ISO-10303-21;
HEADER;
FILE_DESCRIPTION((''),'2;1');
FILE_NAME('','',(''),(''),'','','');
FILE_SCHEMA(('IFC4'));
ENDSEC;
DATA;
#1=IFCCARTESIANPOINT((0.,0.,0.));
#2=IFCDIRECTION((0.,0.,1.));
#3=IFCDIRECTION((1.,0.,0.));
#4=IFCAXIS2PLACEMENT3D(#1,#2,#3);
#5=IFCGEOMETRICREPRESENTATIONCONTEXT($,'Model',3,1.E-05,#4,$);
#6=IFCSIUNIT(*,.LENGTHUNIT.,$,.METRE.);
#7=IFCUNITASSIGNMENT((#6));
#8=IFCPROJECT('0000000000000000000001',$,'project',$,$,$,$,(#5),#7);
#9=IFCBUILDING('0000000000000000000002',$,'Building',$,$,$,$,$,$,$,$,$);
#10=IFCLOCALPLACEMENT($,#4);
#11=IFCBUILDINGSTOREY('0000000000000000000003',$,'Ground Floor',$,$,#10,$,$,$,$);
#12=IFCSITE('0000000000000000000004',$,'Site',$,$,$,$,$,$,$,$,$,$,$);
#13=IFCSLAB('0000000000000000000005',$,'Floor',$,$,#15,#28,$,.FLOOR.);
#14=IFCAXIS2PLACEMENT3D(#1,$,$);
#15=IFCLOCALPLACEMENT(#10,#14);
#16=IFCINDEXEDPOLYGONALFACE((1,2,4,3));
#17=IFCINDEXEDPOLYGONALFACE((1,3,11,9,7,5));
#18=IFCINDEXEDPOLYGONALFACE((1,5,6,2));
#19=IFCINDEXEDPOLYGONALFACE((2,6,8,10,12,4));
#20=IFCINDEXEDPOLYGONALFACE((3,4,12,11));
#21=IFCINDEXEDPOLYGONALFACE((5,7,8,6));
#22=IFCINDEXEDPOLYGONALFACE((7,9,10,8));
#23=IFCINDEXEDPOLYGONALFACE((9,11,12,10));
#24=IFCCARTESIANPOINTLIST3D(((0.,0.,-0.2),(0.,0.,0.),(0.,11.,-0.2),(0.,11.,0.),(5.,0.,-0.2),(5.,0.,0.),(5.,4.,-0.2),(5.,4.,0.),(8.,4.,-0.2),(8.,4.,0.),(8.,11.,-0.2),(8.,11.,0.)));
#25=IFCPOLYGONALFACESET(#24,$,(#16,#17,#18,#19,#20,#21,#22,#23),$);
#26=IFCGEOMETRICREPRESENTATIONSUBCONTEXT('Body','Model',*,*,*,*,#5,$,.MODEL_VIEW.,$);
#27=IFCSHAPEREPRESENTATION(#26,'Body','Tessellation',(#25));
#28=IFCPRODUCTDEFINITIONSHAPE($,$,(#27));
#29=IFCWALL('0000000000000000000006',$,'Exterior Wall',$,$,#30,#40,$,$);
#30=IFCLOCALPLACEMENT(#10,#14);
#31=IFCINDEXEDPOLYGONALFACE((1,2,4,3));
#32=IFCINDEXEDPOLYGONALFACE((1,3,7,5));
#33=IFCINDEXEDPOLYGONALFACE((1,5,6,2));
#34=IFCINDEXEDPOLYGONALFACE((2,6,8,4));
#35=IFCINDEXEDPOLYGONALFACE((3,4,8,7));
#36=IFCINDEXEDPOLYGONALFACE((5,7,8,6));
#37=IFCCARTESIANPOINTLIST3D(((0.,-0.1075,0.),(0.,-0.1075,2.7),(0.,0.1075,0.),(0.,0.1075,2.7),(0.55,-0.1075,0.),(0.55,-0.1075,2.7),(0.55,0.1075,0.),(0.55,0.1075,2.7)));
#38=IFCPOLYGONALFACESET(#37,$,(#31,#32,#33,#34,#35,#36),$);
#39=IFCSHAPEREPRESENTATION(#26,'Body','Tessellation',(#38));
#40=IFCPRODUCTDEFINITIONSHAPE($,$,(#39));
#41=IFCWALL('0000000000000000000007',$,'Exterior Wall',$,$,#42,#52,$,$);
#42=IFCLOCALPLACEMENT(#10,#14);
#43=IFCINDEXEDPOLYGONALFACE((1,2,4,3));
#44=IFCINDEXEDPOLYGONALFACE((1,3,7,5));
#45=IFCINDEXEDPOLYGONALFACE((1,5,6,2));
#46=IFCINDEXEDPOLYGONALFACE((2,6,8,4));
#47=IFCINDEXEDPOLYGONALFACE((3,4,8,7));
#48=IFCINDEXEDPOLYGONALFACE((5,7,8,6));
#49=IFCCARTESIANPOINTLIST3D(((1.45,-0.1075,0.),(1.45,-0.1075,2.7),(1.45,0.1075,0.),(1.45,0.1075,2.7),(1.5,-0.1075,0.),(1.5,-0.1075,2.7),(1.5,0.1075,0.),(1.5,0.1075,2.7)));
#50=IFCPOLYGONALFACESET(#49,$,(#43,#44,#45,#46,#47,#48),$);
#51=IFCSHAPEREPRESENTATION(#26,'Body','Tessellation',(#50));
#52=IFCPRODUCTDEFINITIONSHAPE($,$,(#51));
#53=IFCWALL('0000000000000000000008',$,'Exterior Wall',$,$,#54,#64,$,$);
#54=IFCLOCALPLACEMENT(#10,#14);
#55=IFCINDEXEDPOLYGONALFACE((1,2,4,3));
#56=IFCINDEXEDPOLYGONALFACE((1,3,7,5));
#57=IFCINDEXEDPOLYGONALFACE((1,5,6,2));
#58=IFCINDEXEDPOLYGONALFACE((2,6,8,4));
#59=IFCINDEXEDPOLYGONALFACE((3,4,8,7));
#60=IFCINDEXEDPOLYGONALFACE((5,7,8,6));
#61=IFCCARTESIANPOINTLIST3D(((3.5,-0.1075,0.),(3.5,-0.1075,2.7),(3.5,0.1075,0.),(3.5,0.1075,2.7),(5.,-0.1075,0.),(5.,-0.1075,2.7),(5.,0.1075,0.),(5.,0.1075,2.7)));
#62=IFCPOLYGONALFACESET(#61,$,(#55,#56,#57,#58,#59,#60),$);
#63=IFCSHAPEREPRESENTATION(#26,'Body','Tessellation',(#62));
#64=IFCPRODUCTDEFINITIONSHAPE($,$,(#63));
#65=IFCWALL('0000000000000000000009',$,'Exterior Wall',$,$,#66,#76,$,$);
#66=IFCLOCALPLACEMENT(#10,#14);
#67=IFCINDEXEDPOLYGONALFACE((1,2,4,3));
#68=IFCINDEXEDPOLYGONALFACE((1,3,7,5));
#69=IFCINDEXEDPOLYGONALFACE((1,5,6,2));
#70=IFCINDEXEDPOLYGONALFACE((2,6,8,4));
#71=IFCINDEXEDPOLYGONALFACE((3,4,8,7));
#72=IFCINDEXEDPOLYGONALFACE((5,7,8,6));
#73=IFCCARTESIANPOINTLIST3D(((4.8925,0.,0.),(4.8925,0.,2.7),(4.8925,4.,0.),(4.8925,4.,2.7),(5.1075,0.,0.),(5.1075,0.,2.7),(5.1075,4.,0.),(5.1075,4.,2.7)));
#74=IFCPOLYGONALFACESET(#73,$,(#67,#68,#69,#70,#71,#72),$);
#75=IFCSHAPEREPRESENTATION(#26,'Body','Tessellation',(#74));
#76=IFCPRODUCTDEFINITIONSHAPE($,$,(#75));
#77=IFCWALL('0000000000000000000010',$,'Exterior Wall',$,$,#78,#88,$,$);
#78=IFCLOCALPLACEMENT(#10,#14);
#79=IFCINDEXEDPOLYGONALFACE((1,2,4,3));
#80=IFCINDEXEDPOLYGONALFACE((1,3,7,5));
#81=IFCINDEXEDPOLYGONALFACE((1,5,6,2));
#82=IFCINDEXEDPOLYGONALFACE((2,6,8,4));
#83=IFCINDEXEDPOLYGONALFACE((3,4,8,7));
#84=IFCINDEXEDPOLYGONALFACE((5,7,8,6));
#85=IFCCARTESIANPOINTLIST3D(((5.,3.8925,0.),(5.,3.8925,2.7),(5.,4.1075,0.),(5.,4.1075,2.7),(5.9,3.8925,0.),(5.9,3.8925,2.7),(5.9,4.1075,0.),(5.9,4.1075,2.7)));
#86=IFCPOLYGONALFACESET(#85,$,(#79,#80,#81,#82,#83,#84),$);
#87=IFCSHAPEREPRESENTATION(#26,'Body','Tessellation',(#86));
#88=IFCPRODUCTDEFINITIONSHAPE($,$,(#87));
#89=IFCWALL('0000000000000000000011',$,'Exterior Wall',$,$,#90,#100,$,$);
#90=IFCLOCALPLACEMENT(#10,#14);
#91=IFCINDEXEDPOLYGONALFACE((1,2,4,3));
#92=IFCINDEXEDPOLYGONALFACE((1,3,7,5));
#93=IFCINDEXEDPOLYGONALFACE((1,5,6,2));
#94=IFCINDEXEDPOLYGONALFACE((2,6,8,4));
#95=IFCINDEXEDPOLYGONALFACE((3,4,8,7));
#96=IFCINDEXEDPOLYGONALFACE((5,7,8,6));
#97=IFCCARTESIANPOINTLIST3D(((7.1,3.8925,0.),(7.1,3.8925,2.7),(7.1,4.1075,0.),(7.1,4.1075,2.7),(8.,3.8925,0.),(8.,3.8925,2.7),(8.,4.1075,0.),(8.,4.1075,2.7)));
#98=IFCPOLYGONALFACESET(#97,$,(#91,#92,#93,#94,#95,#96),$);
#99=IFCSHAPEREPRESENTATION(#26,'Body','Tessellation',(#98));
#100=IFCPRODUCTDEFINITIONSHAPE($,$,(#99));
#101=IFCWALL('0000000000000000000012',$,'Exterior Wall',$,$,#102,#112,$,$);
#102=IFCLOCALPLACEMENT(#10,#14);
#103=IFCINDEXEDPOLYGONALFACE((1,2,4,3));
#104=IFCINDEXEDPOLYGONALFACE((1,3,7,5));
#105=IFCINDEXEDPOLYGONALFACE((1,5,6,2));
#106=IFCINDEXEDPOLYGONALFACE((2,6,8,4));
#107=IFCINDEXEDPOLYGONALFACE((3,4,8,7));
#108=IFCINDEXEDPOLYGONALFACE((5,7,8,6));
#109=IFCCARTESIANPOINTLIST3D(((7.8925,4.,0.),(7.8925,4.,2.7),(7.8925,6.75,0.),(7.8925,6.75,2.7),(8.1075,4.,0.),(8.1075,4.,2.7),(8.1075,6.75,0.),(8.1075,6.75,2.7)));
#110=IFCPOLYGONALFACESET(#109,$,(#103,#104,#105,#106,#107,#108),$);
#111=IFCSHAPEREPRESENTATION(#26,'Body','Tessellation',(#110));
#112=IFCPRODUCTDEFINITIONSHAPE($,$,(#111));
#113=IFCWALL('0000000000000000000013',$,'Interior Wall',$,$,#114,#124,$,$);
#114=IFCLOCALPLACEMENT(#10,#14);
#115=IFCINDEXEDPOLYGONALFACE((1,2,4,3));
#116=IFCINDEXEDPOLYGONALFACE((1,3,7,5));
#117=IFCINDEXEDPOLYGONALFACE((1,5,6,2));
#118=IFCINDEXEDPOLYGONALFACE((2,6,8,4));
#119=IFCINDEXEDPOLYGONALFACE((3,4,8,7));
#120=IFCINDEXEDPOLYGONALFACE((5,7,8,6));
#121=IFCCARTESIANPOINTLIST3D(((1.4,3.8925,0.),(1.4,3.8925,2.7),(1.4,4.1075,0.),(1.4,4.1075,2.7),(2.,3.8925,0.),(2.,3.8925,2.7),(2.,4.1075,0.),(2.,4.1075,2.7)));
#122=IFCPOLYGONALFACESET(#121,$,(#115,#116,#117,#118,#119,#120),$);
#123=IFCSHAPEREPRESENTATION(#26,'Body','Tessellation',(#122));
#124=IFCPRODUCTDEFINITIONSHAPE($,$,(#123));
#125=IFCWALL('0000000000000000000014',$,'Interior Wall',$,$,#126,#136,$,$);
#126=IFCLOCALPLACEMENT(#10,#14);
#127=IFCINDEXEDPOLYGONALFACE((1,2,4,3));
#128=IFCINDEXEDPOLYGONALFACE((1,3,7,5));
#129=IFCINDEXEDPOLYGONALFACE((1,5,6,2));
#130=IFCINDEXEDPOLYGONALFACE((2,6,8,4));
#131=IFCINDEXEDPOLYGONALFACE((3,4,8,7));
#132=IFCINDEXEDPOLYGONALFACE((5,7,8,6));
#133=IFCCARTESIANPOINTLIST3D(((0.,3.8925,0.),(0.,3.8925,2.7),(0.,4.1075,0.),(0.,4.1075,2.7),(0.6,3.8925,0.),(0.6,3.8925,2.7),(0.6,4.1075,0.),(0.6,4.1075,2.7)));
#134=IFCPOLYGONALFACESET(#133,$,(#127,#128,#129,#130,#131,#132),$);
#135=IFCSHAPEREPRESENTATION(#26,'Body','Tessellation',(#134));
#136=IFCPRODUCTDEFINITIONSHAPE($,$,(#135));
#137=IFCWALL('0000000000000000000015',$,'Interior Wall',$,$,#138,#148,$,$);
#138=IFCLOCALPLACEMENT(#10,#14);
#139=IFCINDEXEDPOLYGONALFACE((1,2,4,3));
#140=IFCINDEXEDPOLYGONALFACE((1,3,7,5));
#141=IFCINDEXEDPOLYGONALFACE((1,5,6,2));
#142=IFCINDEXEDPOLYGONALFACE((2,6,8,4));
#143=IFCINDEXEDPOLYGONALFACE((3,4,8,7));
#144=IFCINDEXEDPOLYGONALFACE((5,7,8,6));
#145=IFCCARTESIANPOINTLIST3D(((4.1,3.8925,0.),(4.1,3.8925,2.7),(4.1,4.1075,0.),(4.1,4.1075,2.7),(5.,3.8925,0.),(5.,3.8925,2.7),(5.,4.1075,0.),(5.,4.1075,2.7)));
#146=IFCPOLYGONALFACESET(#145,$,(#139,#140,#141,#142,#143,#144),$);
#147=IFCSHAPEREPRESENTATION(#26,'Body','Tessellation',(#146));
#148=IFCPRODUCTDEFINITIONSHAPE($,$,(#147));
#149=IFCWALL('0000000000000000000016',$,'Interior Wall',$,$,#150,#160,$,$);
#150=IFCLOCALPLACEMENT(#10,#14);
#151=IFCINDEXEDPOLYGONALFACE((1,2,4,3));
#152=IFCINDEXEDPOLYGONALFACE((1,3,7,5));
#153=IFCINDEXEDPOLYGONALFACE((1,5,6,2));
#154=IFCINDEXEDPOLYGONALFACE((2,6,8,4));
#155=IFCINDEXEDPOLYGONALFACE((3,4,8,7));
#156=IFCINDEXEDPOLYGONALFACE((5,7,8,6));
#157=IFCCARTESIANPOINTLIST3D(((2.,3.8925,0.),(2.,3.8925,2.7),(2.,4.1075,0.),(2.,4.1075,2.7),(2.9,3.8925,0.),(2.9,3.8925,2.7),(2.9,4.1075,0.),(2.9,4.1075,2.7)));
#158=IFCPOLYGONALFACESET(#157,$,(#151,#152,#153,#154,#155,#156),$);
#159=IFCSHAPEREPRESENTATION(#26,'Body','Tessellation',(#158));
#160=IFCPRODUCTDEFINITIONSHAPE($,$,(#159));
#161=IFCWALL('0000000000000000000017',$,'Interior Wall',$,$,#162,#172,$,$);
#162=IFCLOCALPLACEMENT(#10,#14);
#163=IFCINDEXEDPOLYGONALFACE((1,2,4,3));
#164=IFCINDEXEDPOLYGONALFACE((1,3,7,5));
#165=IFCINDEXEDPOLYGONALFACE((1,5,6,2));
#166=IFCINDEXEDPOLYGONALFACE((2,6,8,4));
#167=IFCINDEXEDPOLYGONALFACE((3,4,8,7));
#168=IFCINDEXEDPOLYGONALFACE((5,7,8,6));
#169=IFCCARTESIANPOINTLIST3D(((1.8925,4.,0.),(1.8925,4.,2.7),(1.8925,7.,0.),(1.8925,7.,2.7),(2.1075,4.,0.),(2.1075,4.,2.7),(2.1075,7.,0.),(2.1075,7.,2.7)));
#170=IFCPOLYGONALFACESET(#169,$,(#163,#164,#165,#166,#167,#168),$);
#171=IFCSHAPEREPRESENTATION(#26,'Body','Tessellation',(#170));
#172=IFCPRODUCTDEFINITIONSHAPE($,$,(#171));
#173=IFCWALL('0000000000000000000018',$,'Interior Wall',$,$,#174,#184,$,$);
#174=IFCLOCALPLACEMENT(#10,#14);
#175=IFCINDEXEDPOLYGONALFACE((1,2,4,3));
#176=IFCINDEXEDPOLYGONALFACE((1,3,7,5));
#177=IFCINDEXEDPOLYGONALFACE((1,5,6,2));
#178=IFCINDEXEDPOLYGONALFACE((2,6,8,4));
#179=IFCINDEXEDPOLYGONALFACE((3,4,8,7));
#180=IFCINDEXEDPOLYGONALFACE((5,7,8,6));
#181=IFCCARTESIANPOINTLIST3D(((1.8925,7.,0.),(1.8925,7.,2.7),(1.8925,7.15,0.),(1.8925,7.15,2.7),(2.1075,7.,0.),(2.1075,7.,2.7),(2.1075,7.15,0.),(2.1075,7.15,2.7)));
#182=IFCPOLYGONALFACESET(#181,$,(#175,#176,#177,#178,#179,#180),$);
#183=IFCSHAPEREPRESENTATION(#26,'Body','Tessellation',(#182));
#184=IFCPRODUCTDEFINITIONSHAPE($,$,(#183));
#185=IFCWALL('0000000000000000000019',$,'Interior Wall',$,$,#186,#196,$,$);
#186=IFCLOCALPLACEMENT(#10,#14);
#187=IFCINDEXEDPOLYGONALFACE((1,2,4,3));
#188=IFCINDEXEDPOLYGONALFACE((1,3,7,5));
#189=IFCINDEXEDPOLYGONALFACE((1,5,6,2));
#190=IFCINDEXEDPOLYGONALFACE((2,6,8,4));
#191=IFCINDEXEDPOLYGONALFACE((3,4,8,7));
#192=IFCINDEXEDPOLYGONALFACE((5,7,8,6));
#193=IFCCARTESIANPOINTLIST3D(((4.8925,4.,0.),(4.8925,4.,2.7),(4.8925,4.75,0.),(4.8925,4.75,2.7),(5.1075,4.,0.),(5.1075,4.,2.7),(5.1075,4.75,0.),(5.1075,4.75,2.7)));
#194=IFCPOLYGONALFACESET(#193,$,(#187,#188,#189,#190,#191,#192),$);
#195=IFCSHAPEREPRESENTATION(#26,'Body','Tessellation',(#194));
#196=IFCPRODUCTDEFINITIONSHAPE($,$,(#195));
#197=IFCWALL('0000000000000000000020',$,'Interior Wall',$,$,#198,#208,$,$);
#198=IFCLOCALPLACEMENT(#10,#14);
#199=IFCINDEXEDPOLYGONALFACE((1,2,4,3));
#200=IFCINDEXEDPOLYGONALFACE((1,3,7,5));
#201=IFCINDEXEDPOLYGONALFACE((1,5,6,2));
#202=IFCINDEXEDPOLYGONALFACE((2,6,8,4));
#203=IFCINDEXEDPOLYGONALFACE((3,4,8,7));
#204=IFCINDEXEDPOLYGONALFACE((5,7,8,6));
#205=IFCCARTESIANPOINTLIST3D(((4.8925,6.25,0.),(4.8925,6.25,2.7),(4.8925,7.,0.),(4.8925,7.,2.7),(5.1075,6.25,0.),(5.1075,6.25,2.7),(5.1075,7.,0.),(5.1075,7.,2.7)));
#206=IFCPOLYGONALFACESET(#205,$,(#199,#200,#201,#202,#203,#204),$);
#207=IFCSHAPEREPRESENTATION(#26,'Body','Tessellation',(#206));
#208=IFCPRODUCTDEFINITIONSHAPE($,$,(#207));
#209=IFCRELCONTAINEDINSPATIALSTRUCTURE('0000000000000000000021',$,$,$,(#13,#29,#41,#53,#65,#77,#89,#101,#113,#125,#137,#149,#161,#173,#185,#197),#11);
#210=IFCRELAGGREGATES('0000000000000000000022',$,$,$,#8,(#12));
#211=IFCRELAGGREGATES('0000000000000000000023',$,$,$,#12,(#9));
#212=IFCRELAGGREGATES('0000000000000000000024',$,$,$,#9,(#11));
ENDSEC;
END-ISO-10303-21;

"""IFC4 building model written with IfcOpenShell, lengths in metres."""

from ifc_helpers import new_model, si_unit, frame, origin_with_axes, place, context, subcontext, project, spatial, indexed_curve, outline, extrude, element, save


model = new_model("IFC4")

# Units and contexts
model_context = context("Model", 3, precision=1e-05, world=origin_with_axes())
body_context = subcontext(model_context, "Body", "Model", "MODEL_VIEW")
ifc_project = project(units=[si_unit("LENGTHUNIT", "METRE")], contexts=[model_context])

# Site, building, storey
site = spatial("IfcSite", under=ifc_project, Name="Site")
building = spatial("IfcBuilding", under=site, Name="Building")
storey_placement = place(None, origin_with_axes())
storey = spatial("IfcBuildingStorey", under=building, at=storey_placement, Name="Ground Floor")

# Slab
slab_placement = place(storey_placement, frame((0.0, 0.0, -0.2), z_axis=(0.0, 0.0, 1.0), x_axis=(1.0, 0.0, 0.0)))
element("IfcSlab", 1, at=slab_placement, inside=storey, Name="Floor", PredefinedType="FLOOR", context=body_context, shape_type="SweptSolid", body=[
    extrude(outline(indexed_curve([(0.0, 0.0), (5.0, 0.0), (5.0, 4.0), (8.0, 4.0), (8.0, 11.0), (0.0, 11.0)])), None, (0.0, 0.0, 1.0), 0.2),
])

# Walls
wall_1_placement = place(storey_placement, origin_with_axes())
element("IfcWall", 2, at=wall_1_placement, inside=storey, Name="Exterior Wall", context=body_context, shape_type="SweptSolid", body=[
    extrude(outline(indexed_curve([(0.0, 0.0), (0.0, 0.215), (0.55, 0.215), (0.55, 0.0), (0.0, 0.0)], self_intersect=False)), frame((0.0, -0.1075, 0.0), z_axis=(0.0, 0.0, 1.0), x_axis=(1.0, 0.0, 0.0)), (0.0, 0.0, 1.0), 2.7),
])
wall_2_placement = place(storey_placement, frame((1.45, 0.0, 0.0), z_axis=(0.0, 0.0, 1.0), x_axis=(1.0, 0.0, 0.0)))
element("IfcWall", 3, at=wall_2_placement, inside=storey, Name="Exterior Wall", context=body_context, shape_type="SweptSolid", body=[
    extrude(outline(indexed_curve([(0.0, 0.0), (0.0, 0.215), (0.05, 0.215), (0.05, 0.0), (0.0, 0.0)], self_intersect=False)), frame((0.0, -0.1075, 0.0), z_axis=(0.0, 0.0, 1.0), x_axis=(1.0, 0.0, 0.0)), (0.0, 0.0, 1.0), 2.7),
])
wall_3_placement = place(storey_placement, frame((3.5, 0.0, 0.0), z_axis=(0.0, 0.0, 1.0), x_axis=(1.0, 0.0, 0.0)))
element("IfcWall", 4, at=wall_3_placement, inside=storey, Name="Exterior Wall", context=body_context, shape_type="SweptSolid", body=[
    extrude(outline(indexed_curve([(0.0, 0.0), (0.0, 0.215), (1.5, 0.215), (1.5, 0.0), (0.0, 0.0)], self_intersect=False)), frame((0.0, -0.1075, 0.0), z_axis=(0.0, 0.0, 1.0), x_axis=(1.0, 0.0, 0.0)), (0.0, 0.0, 1.0), 2.7),
])
wall_4_placement = place(storey_placement, frame((5.0, 0.0, 0.0), z_axis=(0.0, 0.0, 1.0), x_axis=(0.0, 1.0, 0.0)))
element("IfcWall", 5, at=wall_4_placement, inside=storey, Name="Exterior Wall", context=body_context, shape_type="SweptSolid", body=[
    extrude(outline(indexed_curve([(0.0, 0.0), (0.0, 0.215), (4.0, 0.215), (4.0, 0.0), (0.0, 0.0)], self_intersect=False)), frame((0.0, -0.1075, 0.0), z_axis=(0.0, 0.0, 1.0), x_axis=(1.0, 0.0, 0.0)), (0.0, 0.0, 1.0), 2.7),
])
for number, where, z_axis, x_axis, name in (
    (6, (5.0, 4.0, 0.0), (0.0, 0.0, 1.0), (1.0, 0.0, 0.0), "Exterior Wall"),
    (7, (7.1, 4.0, 0.0), (0.0, 0.0, 1.0), (1.0, 0.0, 0.0), "Exterior Wall"),
):
    element("IfcWall", number, at=place(storey_placement, frame(where, z_axis=z_axis, x_axis=x_axis)), inside=storey, Name=name, context=body_context, shape_type="SweptSolid", body=[
        extrude(outline(indexed_curve([(0.0, 0.0), (0.0, 0.215), (0.9, 0.215), (0.9, 0.0), (0.0, 0.0)], self_intersect=False)), frame((0.0, -0.1075, 0.0), z_axis=(0.0, 0.0, 1.0), x_axis=(1.0, 0.0, 0.0)), (0.0, 0.0, 1.0), 2.7),
    ])
wall_5_placement = place(storey_placement, frame((8.0, 4.0, 0.0), z_axis=(0.0, 0.0, 1.0), x_axis=(0.0, 1.0, 0.0)))
element("IfcWall", 8, at=wall_5_placement, inside=storey, Name="Exterior Wall", context=body_context, shape_type="SweptSolid", body=[
    extrude(outline(indexed_curve([(0.0, 0.0), (0.0, 0.215), (2.75, 0.215), (2.75, 0.0), (0.0, 0.0)], self_intersect=False)), frame((0.0, -0.1075, 0.0), z_axis=(0.0, 0.0, 1.0), x_axis=(1.0, 0.0, 0.0)), (0.0, 0.0, 1.0), 2.7),
])
for number, where, z_axis, x_axis, name in (
    (9, (2.0, 4.0, 0.0), (0.0, 0.0, 1.0), (-1.0, 0.0, 0.0), "Interior Wall"),
    (10, (0.6, 4.0, 0.0), (0.0, 0.0, 1.0), (-1.0, 0.0, 0.0), "Interior Wall"),
):
    element("IfcWall", number, at=place(storey_placement, frame(where, z_axis=z_axis, x_axis=x_axis)), inside=storey, Name=name, context=body_context, shape_type="SweptSolid", body=[
        extrude(outline(indexed_curve([(0.0, 0.0), (0.0, 0.215), (0.6, 0.215), (0.6, 0.0), (0.0, 0.0)], self_intersect=False)), frame((0.0, -0.1075, 0.0), z_axis=(0.0, 0.0, 1.0), x_axis=(1.0, 0.0, 0.0)), (0.0, 0.0, 1.0), 2.7),
    ])
wall_6_placement = place(storey_placement, frame((5.0, 4.0, 0.0), z_axis=(0.0, 0.0, 1.0), x_axis=(-1.0, 0.0, 0.0)))
element("IfcWall", 11, at=wall_6_placement, inside=storey, Name="Interior Wall", context=body_context, shape_type="SweptSolid", body=[
    extrude(outline(indexed_curve([(0.0, 0.0), (0.0, 0.215), (0.9, 0.215), (0.9, 0.0), (0.0, 0.0)], self_intersect=False)), frame((0.0, -0.1075, 0.0), z_axis=(0.0, 0.0, 1.0), x_axis=(1.0, 0.0, 0.0)), (0.0, 0.0, 1.0), 2.7),
])
wall_7_placement = place(storey_placement, frame((2.9, 4.0, 0.0), z_axis=(0.0, 0.0, 1.0), x_axis=(-1.0, 0.0, 0.0)))
element("IfcWall", 12, at=wall_7_placement, inside=storey, Name="Interior Wall", context=body_context, shape_type="SweptSolid", body=[
    extrude(outline(indexed_curve([(0.0, 0.0), (0.0, 0.215), (0.9, 0.215), (0.9, 0.0), (0.0, 0.0)], self_intersect=False)), frame((0.0, -0.1075, 0.0), z_axis=(0.0, 0.0, 1.0), x_axis=(1.0, 0.0, 0.0)), (0.0, 0.0, 1.0), 2.7),
])
wall_8_placement = place(storey_placement, frame((2.0, 4.0, 0.0), z_axis=(0.0, 0.0, 1.0), x_axis=(0.0, 1.0, 0.0)))
element("IfcWall", 13, at=wall_8_placement, inside=storey, Name="Interior Wall", context=body_context, shape_type="SweptSolid", body=[
    extrude(outline(indexed_curve([(0.0, 0.0), (0.0, 0.215), (3.0, 0.215), (3.0, 0.0), (0.0, 0.0)], self_intersect=False)), frame((0.0, -0.1075, 0.0), z_axis=(0.0, 0.0, 1.0), x_axis=(1.0, 0.0, 0.0)), (0.0, 0.0, 1.0), 2.7),
])
wall_9_placement = place(storey_placement, frame((2.0, 7.0, 0.0), z_axis=(0.0, 0.0, 1.0), x_axis=(0.0, 1.0, 0.0)))
element("IfcWall", 14, at=wall_9_placement, inside=storey, Name="Interior Wall", context=body_context, shape_type="SweptSolid", body=[
    extrude(outline(indexed_curve([(0.0, 0.0), (0.0, 0.215), (0.15, 0.215), (0.15, 0.0), (0.0, 0.0)], self_intersect=False)), frame((0.0, -0.1075, 0.0), z_axis=(0.0, 0.0, 1.0), x_axis=(1.0, 0.0, 0.0)), (0.0, 0.0, 1.0), 2.7),
])
for number, where, z_axis, x_axis, name in (
    (15, (5.0, 4.0, 0.0), (0.0, 0.0, 1.0), (0.0, 1.0, 0.0), "Interior Wall"),
    (16, (5.0, 6.25, 0.0), (0.0, 0.0, 1.0), (0.0, 1.0, 0.0), "Interior Wall"),
):
    element("IfcWall", number, at=place(storey_placement, frame(where, z_axis=z_axis, x_axis=x_axis)), inside=storey, Name=name, context=body_context, shape_type="SweptSolid", body=[
        extrude(outline(indexed_curve([(0.0, 0.0), (0.0, 0.215), (0.75, 0.215), (0.75, 0.0), (0.0, 0.0)], self_intersect=False)), frame((0.0, -0.1075, 0.0), z_axis=(0.0, 0.0, 1.0), x_axis=(1.0, 0.0, 0.0)), (0.0, 0.0, 1.0), 2.7),
    ])

save(model, "model.ifc")
